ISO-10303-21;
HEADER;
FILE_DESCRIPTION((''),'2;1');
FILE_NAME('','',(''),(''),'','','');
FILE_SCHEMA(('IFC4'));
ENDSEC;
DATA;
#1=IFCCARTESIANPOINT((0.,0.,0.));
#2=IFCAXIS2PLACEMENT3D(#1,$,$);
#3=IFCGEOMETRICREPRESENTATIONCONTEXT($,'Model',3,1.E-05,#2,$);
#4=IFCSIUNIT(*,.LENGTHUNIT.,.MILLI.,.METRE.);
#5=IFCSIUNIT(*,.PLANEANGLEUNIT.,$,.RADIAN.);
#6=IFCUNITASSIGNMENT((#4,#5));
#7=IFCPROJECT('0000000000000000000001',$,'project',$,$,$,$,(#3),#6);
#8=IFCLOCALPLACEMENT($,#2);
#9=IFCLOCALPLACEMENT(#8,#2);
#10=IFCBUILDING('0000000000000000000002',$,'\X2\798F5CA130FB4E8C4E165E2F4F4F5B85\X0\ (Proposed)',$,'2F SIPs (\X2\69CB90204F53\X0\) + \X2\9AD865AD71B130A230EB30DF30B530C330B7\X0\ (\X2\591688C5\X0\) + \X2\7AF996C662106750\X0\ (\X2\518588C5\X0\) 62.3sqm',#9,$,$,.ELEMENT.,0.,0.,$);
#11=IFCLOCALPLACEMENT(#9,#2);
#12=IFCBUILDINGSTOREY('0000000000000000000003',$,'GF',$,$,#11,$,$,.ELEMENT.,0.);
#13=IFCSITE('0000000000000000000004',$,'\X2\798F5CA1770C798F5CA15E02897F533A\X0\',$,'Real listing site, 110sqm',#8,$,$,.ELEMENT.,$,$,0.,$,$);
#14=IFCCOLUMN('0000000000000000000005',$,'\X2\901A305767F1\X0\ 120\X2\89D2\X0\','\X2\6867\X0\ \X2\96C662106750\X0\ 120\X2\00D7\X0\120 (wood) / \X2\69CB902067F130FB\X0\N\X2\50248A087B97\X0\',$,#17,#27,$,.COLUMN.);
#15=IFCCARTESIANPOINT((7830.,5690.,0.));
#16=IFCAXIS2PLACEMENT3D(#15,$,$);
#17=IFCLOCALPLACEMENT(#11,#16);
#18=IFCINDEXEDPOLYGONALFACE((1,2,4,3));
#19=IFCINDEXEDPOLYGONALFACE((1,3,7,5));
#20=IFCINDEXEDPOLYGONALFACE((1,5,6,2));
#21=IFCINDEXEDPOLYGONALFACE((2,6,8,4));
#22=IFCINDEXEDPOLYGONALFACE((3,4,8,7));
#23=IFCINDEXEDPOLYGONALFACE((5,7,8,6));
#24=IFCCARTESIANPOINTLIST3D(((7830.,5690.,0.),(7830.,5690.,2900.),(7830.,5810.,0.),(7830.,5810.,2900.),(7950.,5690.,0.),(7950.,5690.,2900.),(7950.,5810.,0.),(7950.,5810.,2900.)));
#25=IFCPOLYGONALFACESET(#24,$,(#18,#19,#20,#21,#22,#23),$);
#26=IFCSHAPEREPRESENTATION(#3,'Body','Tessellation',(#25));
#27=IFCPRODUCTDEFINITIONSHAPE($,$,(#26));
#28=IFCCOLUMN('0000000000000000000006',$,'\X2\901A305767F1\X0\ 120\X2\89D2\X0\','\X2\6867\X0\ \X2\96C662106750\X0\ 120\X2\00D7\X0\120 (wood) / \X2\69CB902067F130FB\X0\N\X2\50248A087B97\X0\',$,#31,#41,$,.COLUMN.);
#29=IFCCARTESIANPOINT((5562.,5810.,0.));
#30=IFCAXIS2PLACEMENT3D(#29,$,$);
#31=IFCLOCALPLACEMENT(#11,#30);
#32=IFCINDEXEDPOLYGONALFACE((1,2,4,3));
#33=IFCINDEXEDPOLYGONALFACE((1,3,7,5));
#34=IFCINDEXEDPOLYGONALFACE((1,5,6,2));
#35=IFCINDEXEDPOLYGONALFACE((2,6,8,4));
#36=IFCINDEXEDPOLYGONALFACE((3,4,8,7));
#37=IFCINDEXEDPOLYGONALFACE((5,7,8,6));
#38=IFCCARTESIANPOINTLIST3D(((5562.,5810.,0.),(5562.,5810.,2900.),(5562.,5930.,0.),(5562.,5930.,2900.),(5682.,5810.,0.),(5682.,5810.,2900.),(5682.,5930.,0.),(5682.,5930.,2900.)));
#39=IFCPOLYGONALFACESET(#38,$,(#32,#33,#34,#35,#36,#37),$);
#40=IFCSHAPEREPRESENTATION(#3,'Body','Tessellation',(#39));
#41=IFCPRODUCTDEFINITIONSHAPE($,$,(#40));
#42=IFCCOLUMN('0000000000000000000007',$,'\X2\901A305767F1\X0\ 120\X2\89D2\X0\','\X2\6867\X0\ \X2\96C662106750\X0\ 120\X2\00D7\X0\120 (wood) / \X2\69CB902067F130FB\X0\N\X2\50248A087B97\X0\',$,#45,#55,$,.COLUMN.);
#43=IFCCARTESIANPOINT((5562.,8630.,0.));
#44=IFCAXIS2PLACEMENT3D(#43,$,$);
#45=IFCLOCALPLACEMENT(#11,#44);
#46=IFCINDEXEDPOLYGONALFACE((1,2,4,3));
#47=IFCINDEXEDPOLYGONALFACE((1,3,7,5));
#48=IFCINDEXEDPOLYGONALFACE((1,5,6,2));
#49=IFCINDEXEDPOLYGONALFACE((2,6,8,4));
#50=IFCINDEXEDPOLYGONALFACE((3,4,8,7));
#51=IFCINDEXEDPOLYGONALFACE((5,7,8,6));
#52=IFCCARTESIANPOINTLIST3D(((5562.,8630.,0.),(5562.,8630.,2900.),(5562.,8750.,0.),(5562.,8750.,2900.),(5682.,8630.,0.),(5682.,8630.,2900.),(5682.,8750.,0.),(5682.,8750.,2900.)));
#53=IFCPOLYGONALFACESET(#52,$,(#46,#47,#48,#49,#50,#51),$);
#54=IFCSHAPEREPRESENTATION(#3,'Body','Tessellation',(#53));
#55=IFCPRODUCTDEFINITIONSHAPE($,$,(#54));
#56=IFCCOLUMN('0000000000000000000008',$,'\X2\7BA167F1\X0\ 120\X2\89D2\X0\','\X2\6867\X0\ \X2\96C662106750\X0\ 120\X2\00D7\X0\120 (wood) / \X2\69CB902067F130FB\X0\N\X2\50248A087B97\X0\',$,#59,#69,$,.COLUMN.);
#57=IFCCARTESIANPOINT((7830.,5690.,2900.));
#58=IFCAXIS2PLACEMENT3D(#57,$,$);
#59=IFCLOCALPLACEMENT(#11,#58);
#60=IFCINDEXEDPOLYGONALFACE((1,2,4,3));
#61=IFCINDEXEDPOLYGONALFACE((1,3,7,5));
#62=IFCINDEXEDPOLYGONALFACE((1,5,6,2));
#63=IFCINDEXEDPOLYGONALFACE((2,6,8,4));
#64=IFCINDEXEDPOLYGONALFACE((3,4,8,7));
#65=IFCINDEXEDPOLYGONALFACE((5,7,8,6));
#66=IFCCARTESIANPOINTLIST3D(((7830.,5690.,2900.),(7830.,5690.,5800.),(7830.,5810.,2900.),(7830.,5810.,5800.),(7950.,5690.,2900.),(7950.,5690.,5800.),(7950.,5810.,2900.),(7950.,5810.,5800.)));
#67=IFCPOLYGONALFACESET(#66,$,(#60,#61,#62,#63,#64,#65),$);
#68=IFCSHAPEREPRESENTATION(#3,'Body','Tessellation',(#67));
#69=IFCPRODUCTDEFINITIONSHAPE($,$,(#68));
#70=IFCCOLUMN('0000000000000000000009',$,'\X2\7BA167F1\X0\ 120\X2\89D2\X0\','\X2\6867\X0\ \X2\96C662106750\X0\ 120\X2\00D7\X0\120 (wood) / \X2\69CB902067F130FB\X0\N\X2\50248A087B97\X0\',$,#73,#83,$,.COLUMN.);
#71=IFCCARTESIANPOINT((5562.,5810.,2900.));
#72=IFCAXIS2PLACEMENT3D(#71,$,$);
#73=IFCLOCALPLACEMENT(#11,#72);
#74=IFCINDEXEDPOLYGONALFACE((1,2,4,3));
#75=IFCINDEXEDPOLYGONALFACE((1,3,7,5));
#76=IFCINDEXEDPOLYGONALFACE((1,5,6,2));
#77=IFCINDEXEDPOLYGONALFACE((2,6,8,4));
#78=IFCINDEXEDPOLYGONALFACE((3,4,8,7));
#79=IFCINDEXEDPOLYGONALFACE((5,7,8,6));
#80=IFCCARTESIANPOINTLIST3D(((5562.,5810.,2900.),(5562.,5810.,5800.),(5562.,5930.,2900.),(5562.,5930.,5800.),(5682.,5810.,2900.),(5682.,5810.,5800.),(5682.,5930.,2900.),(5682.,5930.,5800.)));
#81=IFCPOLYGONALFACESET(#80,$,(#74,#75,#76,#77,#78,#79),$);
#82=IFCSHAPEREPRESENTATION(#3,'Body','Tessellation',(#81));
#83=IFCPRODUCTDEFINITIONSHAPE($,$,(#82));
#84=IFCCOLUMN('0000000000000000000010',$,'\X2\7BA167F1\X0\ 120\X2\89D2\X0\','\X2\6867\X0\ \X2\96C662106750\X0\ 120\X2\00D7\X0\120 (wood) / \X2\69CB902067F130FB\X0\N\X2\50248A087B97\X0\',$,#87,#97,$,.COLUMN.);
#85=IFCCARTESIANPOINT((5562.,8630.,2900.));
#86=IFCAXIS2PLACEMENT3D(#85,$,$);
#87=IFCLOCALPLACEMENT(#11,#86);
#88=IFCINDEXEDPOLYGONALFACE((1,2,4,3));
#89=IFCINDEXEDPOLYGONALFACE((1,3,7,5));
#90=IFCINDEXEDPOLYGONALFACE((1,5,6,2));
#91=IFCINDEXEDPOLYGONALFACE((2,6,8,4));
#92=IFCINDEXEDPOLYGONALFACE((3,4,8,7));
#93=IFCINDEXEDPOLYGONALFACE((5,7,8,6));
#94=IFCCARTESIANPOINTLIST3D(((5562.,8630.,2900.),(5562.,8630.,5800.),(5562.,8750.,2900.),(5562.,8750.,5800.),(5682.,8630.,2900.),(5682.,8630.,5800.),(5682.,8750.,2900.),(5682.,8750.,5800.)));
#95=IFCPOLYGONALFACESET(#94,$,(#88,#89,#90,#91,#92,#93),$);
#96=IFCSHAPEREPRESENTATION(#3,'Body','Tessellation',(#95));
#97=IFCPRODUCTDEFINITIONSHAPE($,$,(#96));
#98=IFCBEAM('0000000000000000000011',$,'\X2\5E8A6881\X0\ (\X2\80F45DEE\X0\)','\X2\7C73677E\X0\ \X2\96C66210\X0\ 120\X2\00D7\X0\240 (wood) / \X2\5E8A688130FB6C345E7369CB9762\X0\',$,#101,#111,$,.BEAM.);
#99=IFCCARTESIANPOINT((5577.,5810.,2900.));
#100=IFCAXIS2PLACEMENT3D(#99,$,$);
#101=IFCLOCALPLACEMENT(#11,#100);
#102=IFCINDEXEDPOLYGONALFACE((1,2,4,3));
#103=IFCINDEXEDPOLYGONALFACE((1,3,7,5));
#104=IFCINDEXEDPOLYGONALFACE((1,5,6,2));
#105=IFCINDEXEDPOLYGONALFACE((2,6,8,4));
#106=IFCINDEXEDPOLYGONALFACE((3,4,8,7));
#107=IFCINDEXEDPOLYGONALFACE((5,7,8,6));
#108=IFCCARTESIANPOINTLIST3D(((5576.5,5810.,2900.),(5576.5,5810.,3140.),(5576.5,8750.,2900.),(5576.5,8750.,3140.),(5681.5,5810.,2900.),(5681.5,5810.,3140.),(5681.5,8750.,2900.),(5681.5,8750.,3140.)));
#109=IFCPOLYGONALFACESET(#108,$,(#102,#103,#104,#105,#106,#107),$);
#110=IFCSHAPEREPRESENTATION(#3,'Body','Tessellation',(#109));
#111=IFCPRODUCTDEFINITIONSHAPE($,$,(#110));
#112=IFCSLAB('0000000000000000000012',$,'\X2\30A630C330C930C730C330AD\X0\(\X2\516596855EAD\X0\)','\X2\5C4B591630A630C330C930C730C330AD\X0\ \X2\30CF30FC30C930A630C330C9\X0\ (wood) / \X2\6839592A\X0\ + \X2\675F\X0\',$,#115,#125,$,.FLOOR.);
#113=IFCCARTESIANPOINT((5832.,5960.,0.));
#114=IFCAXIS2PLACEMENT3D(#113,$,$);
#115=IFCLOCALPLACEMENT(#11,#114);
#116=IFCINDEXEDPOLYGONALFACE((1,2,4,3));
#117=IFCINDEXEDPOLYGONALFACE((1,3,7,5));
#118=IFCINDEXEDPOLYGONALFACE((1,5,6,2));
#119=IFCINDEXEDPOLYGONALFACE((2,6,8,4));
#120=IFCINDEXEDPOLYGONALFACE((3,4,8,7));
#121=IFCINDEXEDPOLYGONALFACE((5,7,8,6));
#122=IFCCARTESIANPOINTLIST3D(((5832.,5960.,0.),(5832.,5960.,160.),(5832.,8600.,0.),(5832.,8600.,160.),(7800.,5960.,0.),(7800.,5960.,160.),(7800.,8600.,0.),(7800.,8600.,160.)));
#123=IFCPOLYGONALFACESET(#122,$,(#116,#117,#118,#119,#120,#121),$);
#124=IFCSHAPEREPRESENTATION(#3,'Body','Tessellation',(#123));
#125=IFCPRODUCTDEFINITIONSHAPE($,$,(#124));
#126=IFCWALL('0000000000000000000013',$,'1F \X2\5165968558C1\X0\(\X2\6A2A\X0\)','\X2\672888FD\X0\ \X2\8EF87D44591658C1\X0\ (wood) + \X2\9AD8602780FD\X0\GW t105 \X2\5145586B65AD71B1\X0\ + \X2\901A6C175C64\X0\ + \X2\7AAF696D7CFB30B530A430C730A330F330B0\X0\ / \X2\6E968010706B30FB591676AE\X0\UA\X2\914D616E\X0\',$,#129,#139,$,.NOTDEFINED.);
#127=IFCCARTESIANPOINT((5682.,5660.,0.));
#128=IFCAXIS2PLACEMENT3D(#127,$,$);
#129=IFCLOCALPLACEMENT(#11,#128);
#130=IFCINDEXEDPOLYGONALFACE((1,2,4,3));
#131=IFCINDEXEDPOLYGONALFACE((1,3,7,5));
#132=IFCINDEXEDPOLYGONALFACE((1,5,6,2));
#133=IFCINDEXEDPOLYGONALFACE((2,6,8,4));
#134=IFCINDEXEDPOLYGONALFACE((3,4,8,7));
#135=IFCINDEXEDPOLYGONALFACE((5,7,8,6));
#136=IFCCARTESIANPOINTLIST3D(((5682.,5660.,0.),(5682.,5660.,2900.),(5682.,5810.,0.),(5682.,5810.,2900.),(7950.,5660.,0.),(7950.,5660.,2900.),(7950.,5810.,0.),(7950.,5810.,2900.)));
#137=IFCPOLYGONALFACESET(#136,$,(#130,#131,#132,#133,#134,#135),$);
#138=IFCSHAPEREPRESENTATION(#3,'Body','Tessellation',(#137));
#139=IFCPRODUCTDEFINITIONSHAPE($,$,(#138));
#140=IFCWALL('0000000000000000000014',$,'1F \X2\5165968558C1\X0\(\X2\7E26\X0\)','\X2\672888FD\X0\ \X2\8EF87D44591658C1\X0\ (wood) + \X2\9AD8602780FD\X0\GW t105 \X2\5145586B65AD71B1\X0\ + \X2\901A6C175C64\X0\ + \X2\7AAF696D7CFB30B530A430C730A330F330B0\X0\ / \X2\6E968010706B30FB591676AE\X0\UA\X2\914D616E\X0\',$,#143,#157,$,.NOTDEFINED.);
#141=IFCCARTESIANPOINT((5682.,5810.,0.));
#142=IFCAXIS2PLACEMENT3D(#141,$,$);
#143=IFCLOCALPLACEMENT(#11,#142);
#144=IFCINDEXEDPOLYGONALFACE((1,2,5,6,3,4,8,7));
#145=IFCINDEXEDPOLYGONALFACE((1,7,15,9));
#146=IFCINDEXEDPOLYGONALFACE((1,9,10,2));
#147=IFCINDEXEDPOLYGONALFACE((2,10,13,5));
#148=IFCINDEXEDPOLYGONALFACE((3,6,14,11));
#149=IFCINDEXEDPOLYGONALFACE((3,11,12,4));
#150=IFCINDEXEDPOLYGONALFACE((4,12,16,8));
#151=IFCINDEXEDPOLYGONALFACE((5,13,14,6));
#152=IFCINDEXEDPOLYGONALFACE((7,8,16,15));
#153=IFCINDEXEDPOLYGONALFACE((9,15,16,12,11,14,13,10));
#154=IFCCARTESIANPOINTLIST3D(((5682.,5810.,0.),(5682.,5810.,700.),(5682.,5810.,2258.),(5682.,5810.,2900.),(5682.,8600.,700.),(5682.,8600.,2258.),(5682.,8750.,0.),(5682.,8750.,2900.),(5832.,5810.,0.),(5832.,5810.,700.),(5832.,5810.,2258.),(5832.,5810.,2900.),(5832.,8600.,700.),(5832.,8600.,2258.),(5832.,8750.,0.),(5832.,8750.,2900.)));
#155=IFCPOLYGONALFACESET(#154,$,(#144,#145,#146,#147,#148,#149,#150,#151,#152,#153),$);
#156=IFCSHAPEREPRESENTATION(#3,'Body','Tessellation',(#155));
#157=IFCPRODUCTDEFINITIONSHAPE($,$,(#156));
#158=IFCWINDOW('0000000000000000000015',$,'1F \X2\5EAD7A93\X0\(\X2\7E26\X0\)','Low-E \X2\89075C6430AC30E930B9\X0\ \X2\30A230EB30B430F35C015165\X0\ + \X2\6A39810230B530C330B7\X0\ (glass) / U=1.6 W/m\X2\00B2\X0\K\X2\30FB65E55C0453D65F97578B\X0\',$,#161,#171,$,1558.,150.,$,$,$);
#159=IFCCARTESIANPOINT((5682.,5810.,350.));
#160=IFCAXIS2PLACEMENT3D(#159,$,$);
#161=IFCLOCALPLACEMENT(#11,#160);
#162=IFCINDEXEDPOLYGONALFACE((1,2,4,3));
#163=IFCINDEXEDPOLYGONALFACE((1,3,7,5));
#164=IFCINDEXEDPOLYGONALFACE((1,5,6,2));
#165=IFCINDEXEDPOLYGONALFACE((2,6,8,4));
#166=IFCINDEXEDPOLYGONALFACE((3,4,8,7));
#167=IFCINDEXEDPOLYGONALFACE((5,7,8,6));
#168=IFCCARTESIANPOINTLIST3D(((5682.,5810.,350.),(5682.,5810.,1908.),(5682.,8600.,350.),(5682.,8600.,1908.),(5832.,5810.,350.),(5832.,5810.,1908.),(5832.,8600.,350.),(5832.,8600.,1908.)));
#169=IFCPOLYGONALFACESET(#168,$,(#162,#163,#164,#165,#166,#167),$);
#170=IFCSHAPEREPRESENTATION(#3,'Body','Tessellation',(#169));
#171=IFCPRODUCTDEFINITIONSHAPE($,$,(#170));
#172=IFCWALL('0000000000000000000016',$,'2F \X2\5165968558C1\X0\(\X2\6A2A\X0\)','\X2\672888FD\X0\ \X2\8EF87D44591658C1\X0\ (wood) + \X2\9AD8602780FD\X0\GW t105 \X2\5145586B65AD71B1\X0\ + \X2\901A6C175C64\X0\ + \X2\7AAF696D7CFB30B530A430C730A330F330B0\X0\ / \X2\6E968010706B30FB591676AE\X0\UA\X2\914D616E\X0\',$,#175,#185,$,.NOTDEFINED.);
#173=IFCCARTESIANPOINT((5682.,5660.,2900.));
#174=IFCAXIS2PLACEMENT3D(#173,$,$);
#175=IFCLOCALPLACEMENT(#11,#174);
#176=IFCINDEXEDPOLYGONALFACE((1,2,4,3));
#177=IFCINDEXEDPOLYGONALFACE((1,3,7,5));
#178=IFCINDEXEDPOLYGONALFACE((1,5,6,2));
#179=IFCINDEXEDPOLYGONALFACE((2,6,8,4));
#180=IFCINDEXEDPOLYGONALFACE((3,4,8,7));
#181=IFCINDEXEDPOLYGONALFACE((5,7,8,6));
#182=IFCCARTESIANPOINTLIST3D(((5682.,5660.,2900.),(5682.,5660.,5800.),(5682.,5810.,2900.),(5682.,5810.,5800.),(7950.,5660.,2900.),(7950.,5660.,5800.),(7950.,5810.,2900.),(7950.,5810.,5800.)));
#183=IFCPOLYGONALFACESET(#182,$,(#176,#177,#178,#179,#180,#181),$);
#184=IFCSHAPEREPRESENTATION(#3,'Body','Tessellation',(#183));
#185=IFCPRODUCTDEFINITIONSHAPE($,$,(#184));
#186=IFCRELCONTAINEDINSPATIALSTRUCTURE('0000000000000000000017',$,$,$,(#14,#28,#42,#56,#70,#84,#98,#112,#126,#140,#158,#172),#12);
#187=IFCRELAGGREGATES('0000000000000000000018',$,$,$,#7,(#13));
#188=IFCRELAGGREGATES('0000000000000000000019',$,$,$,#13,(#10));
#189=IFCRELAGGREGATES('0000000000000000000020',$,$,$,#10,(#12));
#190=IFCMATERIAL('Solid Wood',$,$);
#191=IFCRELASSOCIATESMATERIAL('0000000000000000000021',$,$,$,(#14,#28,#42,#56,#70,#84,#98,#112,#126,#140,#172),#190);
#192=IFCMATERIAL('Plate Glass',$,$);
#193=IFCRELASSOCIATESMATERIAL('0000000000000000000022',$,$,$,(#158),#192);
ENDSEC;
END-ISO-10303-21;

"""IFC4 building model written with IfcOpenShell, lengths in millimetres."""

from ifc_helpers import new_model, si_unit, frame, frame_2d, origin, place, context, project, spatial, rectangle, extrude, material, element, fill, save


model = new_model("IFC4")

# Units and contexts
model_context = context("Model", 3, precision=1e-05, world=origin())
ifc_project = project(units=[si_unit("LENGTHUNIT", "METRE", prefix="MILLI"), si_unit("PLANEANGLEUNIT", "RADIAN")], contexts=[model_context])

# Site, building, storey
site_placement = place(None, origin())
site = spatial("IfcSite", under=ifc_project, at=site_placement, Name="福岡県福岡市西区", ObjectType="Real listing site, 110sqm", CompositionType="ELEMENT", RefElevation=0.0)
building_placement = place(site_placement, origin())
building = spatial("IfcBuilding", under=site, at=building_placement, Name="福岡・二世帯住宅 (Proposed)", ObjectType="2F SIPs (構造体) + 高断熱アルミサッシ (外装) + 竹集成材 (内装) 62.3sqm", CompositionType="ELEMENT", ElevationOfRefHeight=0.0, ElevationOfTerrain=0.0)
storey_placement = place(building_placement, origin())
storey = spatial("IfcBuildingStorey", under=building, at=storey_placement, Name="GF", CompositionType="ELEMENT", Elevation=0.0)

# Columns
ifc_material_1 = material(Name="Solid Wood")
column_1_placement = place(storey_placement, frame((7830.0, 5690.0, 0.0)))
element("IfcColumn", 1, at=column_1_placement, inside=storey, material=ifc_material_1, Name="通し柱 120角", Description="桧 集成材 120×120 (wood) / 構造柱・N値計算", PredefinedType="COLUMN", context=model_context, shape_type="SweptSolid", body=[
    extrude(rectangle(XDim=120.0, YDim=120.0, at=frame_2d((60.0, 60.0))), frame((7830.0, 5690.0, 0.0)), (0.0, 0.0, 1.0), 2900.0),
])
column_2_placement = place(storey_placement, frame((5562.0, 5810.0, 0.0)))
element("IfcColumn", 2, at=column_2_placement, inside=storey, material=ifc_material_1, Name="通し柱 120角", Description="桧 集成材 120×120 (wood) / 構造柱・N値計算", PredefinedType="COLUMN", context=model_context, shape_type="SweptSolid", body=[
    extrude(rectangle(XDim=120.0, YDim=120.0, at=frame_2d((60.0, 60.0))), frame((5562.0, 5810.0, 0.0)), (0.0, 0.0, 1.0), 2900.0),
])
column_3_placement = place(storey_placement, frame((5562.0, 8630.0, 0.0)))
element("IfcColumn", 3, at=column_3_placement, inside=storey, material=ifc_material_1, Name="通し柱 120角", Description="桧 集成材 120×120 (wood) / 構造柱・N値計算", PredefinedType="COLUMN", context=model_context, shape_type="SweptSolid", body=[
    extrude(rectangle(XDim=120.0, YDim=120.0, at=frame_2d((60.0, 60.0))), frame((5562.0, 8630.0, 0.0)), (0.0, 0.0, 1.0), 2900.0),
])
column_4_placement = place(storey_placement, frame((7830.0, 5690.0, 2900.0)))
element("IfcColumn", 4, at=column_4_placement, inside=storey, material=ifc_material_1, Name="管柱 120角", Description="桧 集成材 120×120 (wood) / 構造柱・N値計算", PredefinedType="COLUMN", context=model_context, shape_type="SweptSolid", body=[
    extrude(rectangle(XDim=120.0, YDim=120.0, at=frame_2d((60.0, 60.0))), frame((7830.0, 5690.0, 2900.0)), (0.0, 0.0, 1.0), 2900.0),
])
column_5_placement = place(storey_placement, frame((5562.0, 5810.0, 2900.0)))
element("IfcColumn", 5, at=column_5_placement, inside=storey, material=ifc_material_1, Name="管柱 120角", Description="桧 集成材 120×120 (wood) / 構造柱・N値計算", PredefinedType="COLUMN", context=model_context, shape_type="SweptSolid", body=[
    extrude(rectangle(XDim=120.0, YDim=120.0, at=frame_2d((60.0, 60.0))), frame((5562.0, 5810.0, 2900.0)), (0.0, 0.0, 1.0), 2900.0),
])
column_6_placement = place(storey_placement, frame((5562.0, 8630.0, 2900.0)))
element("IfcColumn", 6, at=column_6_placement, inside=storey, material=ifc_material_1, Name="管柱 120角", Description="桧 集成材 120×120 (wood) / 構造柱・N値計算", PredefinedType="COLUMN", context=model_context, shape_type="SweptSolid", body=[
    extrude(rectangle(XDim=120.0, YDim=120.0, at=frame_2d((60.0, 60.0))), frame((5562.0, 8630.0, 2900.0)), (0.0, 0.0, 1.0), 2900.0),
])

# Beam
beam_1_placement = place(storey_placement, frame((5577.0, 5810.0, 2900.0)))
element("IfcBeam", 7, at=beam_1_placement, inside=storey, material=ifc_material_1, Name="床梁 (胴差)", Description="米松 集成 120×240 (wood) / 床梁・水平構面", PredefinedType="BEAM", context=model_context, shape_type="SweptSolid", body=[
    extrude(rectangle(XDim=105.0, YDim=2940.0, at=frame_2d((52.0, 1470.0))), frame((5577.0, 5810.0, 2900.0)), (0.0, 0.0, 1.0), 240.0),
])

# Slab
slab_placement = place(storey_placement, frame((5832.0, 5960.0, 0.0)))
element("IfcSlab", 8, at=slab_placement, inside=storey, material=ifc_material_1, Name="ウッドデッキ(入隅庭)", Description="屋外ウッドデッキ ハードウッド (wood) / 根太 + 束", PredefinedType="FLOOR", context=model_context, shape_type="SweptSolid", body=[
    extrude(rectangle(XDim=1968.0, YDim=2640.0, at=frame_2d((984.0, 1320.0))), frame((5832.0, 5960.0, 0.0)), (0.0, 0.0, 1.0), 160.0),
])

# Wall
wall_1_placement = place(storey_placement, frame((5682.0, 5660.0, 0.0)))
element("IfcWall", 9, at=wall_1_placement, inside=storey, material=ifc_material_1, Name="1F 入隅壁(横)", Description="木製 軸組外壁 (wood) + 高性能GW t105 充填断熱 + 通気層 + 窯業系サイディング / 準耐火・外皮UA配慮", PredefinedType="NOTDEFINED", context=model_context, shape_type="SweptSolid", body=[
    extrude(rectangle(XDim=2268.0, YDim=150.0, at=frame_2d((1134.0, 75.0))), frame((5682.0, 5660.0, 0.0)), (0.0, 0.0, 1.0), 2900.0),
])

# Wall, opening, window
wall_2_placement = place(storey_placement, frame((5682.0, 5810.0, 0.0)))
wall_2 = element("IfcWall", 10, at=wall_2_placement, inside=storey, material=ifc_material_1, Name="1F 入隅壁(縦)", Description="木製 軸組外壁 (wood) + 高性能GW t105 充填断熱 + 通気層 + 窯業系サイディング / 準耐火・外皮UA配慮", PredefinedType="NOTDEFINED", context=model_context, shape_type="SweptSolid", body=[
    extrude(rectangle(XDim=150.0, YDim=2940.0, at=frame_2d((75.0, 1470.0))), frame((5682.0, 5810.0, 0.0)), (0.0, 0.0, 1.0), 2900.0),
])
opening_1_placement = place(storey_placement, frame((5682.0, 5810.0, 350.0)))
opening_1 = element("IfcOpeningElement", 11, at=opening_1_placement, cuts=wall_2, PredefinedType="NOTDEFINED", context=model_context, shape_type="SweptSolid", body=[
    extrude(rectangle(XDim=150.0, YDim=2790.0, at=frame_2d((75.0, 1395.0))), frame((5682.0, 5810.0, 350.0)), (0.0, 0.0, 1.0), 1558.0),
])
ifc_material_2 = material(Name="Plate Glass")
window_1_placement = place(storey_placement, frame((5682.0, 5810.0, 350.0)))
window_1 = element("IfcWindow", 12, at=window_1_placement, inside=storey, material=ifc_material_2, Name="1F 庭窓(縦)", Description="Low-E 複層ガラス アルゴン封入 + 樹脂サッシ (glass) / U=1.6 W/m²K・日射取得型", OverallHeight=1558.0, OverallWidth=150.0, context=model_context, shape_type="SweptSolid", body=[
    extrude(rectangle(XDim=150.0, YDim=2790.0, at=frame_2d((75.0, 1395.0))), frame((5682.0, 5810.0, 350.0)), (0.0, 0.0, 1.0), 1558.0),
])
fill(opening_1, window_1)

# Wall
wall_3_placement = place(storey_placement, frame((5682.0, 5660.0, 2900.0)))
element("IfcWall", 13, at=wall_3_placement, inside=storey, material=ifc_material_1, Name="2F 入隅壁(横)", Description="木製 軸組外壁 (wood) + 高性能GW t105 充填断熱 + 通気層 + 窯業系サイディング / 準耐火・外皮UA配慮", PredefinedType="NOTDEFINED", context=model_context, shape_type="SweptSolid", body=[
    extrude(rectangle(XDim=2268.0, YDim=150.0, at=frame_2d((1134.0, 75.0))), frame((5682.0, 5660.0, 2900.0)), (0.0, 0.0, 1.0), 2900.0),
])

save(model, "model.ifc")
